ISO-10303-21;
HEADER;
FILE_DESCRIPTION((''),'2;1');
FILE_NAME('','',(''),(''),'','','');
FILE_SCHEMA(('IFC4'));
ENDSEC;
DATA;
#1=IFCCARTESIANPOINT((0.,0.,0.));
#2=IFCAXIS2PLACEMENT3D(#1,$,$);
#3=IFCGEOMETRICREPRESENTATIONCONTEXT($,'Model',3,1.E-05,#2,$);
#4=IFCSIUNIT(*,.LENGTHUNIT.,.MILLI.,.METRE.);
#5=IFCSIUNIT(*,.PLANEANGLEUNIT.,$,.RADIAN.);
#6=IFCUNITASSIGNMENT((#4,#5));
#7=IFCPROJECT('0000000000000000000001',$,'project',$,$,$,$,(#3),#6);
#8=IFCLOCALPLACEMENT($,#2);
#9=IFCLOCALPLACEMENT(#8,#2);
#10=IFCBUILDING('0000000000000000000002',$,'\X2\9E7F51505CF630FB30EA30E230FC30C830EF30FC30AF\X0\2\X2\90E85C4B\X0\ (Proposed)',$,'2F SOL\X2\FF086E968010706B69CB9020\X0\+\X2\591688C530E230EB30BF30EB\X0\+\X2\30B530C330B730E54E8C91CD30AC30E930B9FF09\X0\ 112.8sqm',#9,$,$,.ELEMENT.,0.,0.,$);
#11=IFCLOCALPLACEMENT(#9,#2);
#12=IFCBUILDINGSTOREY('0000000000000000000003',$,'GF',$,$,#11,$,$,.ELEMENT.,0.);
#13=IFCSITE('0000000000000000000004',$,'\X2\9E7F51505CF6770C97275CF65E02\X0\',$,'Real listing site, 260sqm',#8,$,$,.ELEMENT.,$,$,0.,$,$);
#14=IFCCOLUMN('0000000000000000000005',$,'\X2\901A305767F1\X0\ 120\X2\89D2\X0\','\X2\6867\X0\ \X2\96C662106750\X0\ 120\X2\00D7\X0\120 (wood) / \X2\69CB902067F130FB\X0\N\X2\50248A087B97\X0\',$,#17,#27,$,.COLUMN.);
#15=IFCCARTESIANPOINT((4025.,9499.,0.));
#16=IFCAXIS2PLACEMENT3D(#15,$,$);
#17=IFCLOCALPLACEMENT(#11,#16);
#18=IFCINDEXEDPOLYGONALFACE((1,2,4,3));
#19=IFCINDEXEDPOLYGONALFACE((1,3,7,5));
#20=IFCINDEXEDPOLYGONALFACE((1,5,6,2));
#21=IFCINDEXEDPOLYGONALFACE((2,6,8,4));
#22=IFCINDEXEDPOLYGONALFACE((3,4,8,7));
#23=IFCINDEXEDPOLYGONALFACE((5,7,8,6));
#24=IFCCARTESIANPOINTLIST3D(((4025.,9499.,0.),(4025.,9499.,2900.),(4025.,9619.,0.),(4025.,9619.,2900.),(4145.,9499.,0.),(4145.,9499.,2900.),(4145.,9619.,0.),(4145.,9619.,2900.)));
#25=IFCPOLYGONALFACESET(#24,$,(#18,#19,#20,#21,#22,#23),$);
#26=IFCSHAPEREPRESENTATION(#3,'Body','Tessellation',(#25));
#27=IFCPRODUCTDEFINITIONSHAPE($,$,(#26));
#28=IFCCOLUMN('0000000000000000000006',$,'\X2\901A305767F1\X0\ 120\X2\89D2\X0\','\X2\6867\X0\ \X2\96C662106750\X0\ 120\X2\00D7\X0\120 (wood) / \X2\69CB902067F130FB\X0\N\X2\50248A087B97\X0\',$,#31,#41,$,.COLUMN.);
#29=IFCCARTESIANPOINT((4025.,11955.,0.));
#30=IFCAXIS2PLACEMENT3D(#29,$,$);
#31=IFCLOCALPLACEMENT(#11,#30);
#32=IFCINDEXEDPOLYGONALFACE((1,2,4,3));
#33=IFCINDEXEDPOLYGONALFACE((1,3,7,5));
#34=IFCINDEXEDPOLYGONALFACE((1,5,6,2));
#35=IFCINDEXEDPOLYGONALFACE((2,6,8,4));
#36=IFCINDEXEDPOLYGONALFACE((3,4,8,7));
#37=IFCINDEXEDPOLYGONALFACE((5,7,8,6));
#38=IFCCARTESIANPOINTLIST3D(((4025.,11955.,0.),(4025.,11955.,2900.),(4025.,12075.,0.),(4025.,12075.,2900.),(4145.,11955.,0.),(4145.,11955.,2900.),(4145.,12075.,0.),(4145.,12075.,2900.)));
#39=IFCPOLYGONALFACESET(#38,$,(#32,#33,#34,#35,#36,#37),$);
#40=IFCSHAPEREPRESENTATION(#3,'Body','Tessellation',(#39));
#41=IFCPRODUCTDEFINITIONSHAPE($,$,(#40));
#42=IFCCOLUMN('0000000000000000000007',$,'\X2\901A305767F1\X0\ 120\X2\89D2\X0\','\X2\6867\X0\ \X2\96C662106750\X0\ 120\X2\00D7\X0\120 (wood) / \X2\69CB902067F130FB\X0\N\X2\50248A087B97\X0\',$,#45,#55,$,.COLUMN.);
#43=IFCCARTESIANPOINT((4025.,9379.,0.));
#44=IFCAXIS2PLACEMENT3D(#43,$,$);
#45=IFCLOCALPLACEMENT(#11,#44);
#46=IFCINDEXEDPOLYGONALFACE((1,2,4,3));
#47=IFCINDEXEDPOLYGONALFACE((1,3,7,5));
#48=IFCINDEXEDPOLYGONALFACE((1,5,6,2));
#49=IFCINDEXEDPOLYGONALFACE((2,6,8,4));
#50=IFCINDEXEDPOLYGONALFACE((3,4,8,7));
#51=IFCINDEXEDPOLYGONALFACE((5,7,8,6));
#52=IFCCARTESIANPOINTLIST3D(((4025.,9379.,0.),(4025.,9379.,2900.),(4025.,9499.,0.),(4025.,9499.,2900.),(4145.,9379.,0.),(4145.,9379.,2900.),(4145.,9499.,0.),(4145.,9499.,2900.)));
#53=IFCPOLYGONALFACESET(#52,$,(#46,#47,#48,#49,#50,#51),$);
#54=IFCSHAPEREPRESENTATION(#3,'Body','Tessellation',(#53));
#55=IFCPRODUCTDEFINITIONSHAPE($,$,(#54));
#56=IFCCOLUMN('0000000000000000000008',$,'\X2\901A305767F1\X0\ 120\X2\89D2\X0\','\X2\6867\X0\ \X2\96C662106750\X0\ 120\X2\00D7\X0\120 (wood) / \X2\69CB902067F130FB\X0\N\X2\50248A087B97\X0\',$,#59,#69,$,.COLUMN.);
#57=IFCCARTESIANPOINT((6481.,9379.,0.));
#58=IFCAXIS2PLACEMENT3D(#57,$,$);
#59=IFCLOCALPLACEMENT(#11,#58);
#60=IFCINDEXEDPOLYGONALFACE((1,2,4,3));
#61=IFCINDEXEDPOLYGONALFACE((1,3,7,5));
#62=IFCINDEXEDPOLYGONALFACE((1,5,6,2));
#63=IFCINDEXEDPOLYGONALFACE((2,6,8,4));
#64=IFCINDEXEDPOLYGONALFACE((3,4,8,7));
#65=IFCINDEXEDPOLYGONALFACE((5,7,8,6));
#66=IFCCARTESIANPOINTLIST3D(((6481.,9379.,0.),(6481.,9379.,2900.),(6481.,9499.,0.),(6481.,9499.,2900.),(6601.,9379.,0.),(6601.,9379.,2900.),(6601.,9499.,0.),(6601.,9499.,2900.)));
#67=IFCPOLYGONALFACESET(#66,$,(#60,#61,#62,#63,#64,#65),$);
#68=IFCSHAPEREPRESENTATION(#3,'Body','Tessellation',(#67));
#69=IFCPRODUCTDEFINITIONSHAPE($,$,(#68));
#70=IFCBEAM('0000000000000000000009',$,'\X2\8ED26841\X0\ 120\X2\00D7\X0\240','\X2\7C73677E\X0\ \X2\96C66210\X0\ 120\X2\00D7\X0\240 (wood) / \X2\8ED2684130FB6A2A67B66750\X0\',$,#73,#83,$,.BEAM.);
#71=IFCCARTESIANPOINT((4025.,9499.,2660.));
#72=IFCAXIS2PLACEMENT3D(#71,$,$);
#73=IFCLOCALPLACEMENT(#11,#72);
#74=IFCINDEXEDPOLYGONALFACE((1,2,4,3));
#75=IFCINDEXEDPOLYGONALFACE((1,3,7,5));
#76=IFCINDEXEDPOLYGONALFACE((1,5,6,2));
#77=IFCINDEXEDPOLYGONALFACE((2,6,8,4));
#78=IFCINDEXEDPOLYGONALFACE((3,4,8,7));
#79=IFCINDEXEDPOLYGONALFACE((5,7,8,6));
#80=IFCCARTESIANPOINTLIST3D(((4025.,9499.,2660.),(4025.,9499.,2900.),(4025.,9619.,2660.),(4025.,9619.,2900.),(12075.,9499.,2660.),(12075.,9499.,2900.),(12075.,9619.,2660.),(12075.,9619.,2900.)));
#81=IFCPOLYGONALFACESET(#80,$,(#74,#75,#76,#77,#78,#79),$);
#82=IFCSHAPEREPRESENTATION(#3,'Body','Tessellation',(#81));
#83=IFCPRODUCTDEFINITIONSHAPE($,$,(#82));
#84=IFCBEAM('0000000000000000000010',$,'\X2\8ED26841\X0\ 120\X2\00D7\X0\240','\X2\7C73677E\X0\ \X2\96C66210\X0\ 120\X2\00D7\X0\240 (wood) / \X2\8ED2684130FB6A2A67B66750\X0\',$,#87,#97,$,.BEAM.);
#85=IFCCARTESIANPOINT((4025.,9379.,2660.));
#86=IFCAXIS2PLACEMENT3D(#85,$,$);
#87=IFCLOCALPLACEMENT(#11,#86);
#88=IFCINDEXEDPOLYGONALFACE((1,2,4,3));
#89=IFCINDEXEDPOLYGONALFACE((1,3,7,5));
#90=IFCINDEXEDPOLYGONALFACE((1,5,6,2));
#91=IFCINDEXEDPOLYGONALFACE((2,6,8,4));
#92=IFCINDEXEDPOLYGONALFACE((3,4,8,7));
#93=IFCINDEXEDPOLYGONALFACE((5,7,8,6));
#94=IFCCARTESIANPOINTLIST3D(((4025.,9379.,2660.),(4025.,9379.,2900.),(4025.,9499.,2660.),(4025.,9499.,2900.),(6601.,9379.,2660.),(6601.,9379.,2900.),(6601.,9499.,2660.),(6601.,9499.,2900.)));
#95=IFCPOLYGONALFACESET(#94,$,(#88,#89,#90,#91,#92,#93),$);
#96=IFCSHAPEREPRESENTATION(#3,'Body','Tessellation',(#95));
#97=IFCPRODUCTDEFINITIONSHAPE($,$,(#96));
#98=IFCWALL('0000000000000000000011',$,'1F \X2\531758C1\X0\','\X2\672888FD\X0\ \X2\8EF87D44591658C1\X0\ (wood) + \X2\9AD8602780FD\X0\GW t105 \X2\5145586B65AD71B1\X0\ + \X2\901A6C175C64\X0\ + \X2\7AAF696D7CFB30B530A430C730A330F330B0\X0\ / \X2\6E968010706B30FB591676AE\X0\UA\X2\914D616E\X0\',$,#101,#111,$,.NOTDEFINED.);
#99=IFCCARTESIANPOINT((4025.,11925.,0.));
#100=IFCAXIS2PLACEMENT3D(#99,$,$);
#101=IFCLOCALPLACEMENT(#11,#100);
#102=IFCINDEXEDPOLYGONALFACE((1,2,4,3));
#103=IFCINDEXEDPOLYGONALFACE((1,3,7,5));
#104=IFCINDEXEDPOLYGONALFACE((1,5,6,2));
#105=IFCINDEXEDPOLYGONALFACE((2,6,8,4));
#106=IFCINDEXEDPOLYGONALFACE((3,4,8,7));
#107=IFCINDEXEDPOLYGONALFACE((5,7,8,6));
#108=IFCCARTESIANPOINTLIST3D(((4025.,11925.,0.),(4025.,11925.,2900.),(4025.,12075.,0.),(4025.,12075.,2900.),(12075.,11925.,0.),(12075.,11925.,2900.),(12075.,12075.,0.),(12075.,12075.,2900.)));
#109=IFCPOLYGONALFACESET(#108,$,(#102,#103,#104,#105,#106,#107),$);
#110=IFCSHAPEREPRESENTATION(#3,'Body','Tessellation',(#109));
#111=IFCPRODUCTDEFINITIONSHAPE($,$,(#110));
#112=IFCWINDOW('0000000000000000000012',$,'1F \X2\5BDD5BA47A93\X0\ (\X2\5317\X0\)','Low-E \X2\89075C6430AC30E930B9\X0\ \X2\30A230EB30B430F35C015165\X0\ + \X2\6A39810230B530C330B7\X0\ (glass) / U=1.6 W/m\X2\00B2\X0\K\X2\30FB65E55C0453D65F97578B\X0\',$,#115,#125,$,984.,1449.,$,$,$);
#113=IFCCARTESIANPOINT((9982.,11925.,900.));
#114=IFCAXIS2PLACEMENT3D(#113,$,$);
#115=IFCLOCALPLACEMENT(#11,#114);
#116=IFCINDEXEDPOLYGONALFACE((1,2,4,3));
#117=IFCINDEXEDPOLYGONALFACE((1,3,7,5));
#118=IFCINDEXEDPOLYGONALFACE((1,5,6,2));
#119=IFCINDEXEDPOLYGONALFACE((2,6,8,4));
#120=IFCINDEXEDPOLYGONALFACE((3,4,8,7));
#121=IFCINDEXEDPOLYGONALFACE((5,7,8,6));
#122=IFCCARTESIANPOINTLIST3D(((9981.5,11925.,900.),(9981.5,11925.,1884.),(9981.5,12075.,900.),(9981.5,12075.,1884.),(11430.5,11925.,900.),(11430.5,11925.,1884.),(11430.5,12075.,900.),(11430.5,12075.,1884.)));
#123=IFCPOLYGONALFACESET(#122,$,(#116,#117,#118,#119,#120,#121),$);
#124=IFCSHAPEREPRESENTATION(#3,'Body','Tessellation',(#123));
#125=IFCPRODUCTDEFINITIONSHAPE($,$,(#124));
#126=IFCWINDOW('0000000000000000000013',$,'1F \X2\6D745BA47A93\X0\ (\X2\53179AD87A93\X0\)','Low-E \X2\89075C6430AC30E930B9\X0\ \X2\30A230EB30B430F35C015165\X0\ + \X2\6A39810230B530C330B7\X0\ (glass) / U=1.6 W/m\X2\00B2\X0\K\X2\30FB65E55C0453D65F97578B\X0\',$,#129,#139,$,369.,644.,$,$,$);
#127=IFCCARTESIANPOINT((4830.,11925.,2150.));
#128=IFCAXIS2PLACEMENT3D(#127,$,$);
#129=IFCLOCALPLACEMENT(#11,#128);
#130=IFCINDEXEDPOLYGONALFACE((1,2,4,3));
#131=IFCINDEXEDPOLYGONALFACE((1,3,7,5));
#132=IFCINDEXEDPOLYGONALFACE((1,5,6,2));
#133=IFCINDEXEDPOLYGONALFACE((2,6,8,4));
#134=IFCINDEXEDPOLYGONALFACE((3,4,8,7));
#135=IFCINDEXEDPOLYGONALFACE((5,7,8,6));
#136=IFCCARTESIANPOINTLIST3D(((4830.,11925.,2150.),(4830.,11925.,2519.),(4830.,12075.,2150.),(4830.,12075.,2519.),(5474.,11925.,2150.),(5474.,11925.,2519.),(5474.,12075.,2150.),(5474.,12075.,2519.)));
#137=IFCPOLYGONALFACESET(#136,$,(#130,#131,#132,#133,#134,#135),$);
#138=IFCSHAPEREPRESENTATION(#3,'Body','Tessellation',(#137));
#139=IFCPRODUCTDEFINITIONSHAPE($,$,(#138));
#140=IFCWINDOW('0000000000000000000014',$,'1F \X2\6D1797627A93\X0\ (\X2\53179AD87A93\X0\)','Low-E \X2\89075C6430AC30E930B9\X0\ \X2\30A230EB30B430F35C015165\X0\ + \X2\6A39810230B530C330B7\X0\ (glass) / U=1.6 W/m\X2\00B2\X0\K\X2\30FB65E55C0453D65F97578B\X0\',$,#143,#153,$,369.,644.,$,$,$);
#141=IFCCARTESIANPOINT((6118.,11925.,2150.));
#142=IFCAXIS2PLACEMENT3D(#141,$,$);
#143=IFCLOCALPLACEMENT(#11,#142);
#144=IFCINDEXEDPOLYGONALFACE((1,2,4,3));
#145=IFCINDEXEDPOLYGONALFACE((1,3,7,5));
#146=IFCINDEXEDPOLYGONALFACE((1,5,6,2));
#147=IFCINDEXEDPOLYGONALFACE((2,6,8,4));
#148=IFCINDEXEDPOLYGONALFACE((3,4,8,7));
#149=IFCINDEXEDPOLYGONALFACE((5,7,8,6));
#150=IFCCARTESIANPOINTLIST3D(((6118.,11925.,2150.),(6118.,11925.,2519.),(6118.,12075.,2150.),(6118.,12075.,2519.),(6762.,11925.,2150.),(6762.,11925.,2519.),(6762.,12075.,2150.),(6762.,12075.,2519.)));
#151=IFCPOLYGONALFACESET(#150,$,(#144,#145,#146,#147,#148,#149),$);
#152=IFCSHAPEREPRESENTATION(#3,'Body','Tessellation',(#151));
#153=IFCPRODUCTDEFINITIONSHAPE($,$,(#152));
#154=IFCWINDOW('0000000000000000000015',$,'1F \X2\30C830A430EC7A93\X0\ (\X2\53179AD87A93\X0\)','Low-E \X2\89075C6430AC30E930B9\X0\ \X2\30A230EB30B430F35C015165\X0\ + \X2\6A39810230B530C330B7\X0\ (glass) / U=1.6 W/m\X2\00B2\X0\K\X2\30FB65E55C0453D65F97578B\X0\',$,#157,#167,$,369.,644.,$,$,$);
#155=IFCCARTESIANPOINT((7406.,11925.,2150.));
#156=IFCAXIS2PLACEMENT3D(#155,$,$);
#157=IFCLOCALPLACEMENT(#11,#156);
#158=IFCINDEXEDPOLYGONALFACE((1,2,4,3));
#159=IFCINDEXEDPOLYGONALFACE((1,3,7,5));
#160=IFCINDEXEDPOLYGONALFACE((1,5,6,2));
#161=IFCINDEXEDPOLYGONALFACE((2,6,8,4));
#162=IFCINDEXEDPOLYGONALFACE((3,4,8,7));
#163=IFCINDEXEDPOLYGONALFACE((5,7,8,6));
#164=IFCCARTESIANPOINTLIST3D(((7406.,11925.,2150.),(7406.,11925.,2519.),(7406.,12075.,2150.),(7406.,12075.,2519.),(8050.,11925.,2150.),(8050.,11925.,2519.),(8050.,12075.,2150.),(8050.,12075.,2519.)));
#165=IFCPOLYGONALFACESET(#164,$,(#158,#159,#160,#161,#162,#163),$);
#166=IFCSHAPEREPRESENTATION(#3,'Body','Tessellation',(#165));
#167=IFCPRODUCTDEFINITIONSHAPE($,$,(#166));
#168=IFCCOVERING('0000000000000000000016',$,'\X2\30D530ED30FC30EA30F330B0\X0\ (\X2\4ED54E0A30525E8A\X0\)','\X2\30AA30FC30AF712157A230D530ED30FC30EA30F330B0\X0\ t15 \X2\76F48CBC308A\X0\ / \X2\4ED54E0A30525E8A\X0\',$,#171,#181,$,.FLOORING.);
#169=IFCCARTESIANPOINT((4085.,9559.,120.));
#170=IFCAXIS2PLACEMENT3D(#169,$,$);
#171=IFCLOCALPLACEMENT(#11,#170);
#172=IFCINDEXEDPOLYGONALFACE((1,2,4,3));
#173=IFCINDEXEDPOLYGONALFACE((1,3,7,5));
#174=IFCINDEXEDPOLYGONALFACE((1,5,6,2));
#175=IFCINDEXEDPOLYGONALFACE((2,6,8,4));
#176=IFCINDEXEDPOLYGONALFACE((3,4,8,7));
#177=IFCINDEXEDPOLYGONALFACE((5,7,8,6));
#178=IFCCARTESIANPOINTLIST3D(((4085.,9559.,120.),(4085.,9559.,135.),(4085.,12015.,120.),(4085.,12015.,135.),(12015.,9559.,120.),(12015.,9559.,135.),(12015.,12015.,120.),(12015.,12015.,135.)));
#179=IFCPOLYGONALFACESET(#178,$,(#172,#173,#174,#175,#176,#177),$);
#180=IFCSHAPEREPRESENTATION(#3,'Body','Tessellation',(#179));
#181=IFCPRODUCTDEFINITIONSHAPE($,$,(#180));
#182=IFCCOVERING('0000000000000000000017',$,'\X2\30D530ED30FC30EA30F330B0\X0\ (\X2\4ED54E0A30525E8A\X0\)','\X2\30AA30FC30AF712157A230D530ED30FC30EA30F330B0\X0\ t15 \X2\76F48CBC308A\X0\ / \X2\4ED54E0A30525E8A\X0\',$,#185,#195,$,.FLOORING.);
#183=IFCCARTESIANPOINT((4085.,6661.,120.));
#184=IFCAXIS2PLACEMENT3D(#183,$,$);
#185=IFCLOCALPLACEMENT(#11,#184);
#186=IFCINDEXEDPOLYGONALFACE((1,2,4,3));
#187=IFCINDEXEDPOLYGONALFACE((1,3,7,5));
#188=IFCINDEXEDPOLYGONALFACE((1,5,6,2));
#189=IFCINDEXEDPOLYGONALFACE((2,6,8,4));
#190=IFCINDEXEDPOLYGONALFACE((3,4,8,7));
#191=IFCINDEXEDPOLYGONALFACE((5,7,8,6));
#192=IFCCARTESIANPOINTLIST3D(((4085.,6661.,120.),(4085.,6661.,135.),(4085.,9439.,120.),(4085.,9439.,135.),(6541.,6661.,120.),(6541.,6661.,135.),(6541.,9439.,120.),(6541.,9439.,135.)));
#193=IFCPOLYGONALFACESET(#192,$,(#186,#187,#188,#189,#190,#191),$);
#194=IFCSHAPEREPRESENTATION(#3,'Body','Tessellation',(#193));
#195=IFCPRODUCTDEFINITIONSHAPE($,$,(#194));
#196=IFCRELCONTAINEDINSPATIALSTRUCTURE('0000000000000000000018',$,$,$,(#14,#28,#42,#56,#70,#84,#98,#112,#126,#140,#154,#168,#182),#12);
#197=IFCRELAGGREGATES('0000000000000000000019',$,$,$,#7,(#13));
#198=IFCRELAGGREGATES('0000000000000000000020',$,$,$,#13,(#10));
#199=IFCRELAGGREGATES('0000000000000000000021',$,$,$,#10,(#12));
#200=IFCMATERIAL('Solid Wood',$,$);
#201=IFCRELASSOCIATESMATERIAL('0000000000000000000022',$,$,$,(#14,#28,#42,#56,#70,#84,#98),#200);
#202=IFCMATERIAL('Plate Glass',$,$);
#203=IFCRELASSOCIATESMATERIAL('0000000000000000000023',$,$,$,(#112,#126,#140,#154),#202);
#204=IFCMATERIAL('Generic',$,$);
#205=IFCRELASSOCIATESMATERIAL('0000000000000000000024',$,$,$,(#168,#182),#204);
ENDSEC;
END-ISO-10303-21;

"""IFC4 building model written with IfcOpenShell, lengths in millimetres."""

from ifc_helpers import new_model, si_unit, frame, frame_2d, origin, place, context, project, spatial, rectangle, extrude, material, element, fill, save


model = new_model("IFC4")

# Units and contexts
model_context = context("Model", 3, precision=1e-05, world=origin())
ifc_project = project(units=[si_unit("LENGTHUNIT", "METRE", prefix="MILLI"), si_unit("PLANEANGLEUNIT", "RADIAN")], contexts=[model_context])

# Site, building, storey
site_placement = place(None, origin())
site = spatial("IfcSite", under=ifc_project, at=site_placement, Name="鹿児島県霧島市", ObjectType="Real listing site, 260sqm", CompositionType="ELEMENT", RefElevation=0.0)
building_placement = place(site_placement, origin())
building = spatial("IfcBuilding", under=site, at=building_placement, Name="鹿児島・リモートワーク2部屋 (Proposed)", ObjectType="2F SOL（準耐火構造+外装モルタル+サッシュ二重ガラス） 112.8sqm", CompositionType="ELEMENT", ElevationOfRefHeight=0.0, ElevationOfTerrain=0.0)
storey_placement = place(building_placement, origin())
storey = spatial("IfcBuildingStorey", under=building, at=storey_placement, Name="GF", CompositionType="ELEMENT", Elevation=0.0)

# Columns
ifc_material_1 = material(Name="Solid Wood")
column_1_placement = place(storey_placement, frame((4025.0, 9499.0, 0.0)))
element("IfcColumn", 1, at=column_1_placement, inside=storey, material=ifc_material_1, Name="通し柱 120角", Description="桧 集成材 120×120 (wood) / 構造柱・N値計算", PredefinedType="COLUMN", context=model_context, shape_type="SweptSolid", body=[
    extrude(rectangle(XDim=120.0, YDim=120.0, at=frame_2d((60.0, 60.0))), frame((4025.0, 9499.0, 0.0)), (0.0, 0.0, 1.0), 2900.0),
])
column_2_placement = place(storey_placement, frame((4025.0, 11955.0, 0.0)))
element("IfcColumn", 2, at=column_2_placement, inside=storey, material=ifc_material_1, Name="通し柱 120角", Description="桧 集成材 120×120 (wood) / 構造柱・N値計算", PredefinedType="COLUMN", context=model_context, shape_type="SweptSolid", body=[
    extrude(rectangle(XDim=120.0, YDim=120.0, at=frame_2d((60.0, 60.0))), frame((4025.0, 11955.0, 0.0)), (0.0, 0.0, 1.0), 2900.0),
])
column_3_placement = place(storey_placement, frame((4025.0, 9379.0, 0.0)))
element("IfcColumn", 3, at=column_3_placement, inside=storey, material=ifc_material_1, Name="通し柱 120角", Description="桧 集成材 120×120 (wood) / 構造柱・N値計算", PredefinedType="COLUMN", context=model_context, shape_type="SweptSolid", body=[
    extrude(rectangle(XDim=120.0, YDim=120.0, at=frame_2d((60.0, 60.0))), frame((4025.0, 9379.0, 0.0)), (0.0, 0.0, 1.0), 2900.0),
])
column_4_placement = place(storey_placement, frame((6481.0, 9379.0, 0.0)))
element("IfcColumn", 4, at=column_4_placement, inside=storey, material=ifc_material_1, Name="通し柱 120角", Description="桧 集成材 120×120 (wood) / 構造柱・N値計算", PredefinedType="COLUMN", context=model_context, shape_type="SweptSolid", body=[
    extrude(rectangle(XDim=120.0, YDim=120.0, at=frame_2d((60.0, 60.0))), frame((6481.0, 9379.0, 0.0)), (0.0, 0.0, 1.0), 2900.0),
])

# Beams
beam_1_placement = place(storey_placement, frame((4025.0, 9499.0, 2660.0)))
element("IfcBeam", 5, at=beam_1_placement, inside=storey, material=ifc_material_1, Name="軒桁 120×240", Description="米松 集成 120×240 (wood) / 軒桁・横架材", PredefinedType="BEAM", context=model_context, shape_type="SweptSolid", body=[
    extrude(rectangle(XDim=8050.0, YDim=120.0, at=frame_2d((4025.0, 60.0))), frame((4025.0, 9499.0, 2660.0)), (0.0, 0.0, 1.0), 240.0),
])
beam_2_placement = place(storey_placement, frame((4025.0, 9379.0, 2660.0)))
element("IfcBeam", 6, at=beam_2_placement, inside=storey, material=ifc_material_1, Name="軒桁 120×240", Description="米松 集成 120×240 (wood) / 軒桁・横架材", PredefinedType="BEAM", context=model_context, shape_type="SweptSolid", body=[
    extrude(rectangle(XDim=2576.0, YDim=120.0, at=frame_2d((1288.0, 60.0))), frame((4025.0, 9379.0, 2660.0)), (0.0, 0.0, 1.0), 240.0),
])

# Wall, openings, windows
wall_1_placement = place(storey_placement, frame((4025.0, 11925.0, 0.0)))
wall_1 = element("IfcWall", 7, at=wall_1_placement, inside=storey, material=ifc_material_1, Name="1F 北壁", Description="木製 軸組外壁 (wood) + 高性能GW t105 充填断熱 + 通気層 + 窯業系サイディング / 準耐火・外皮UA配慮", PredefinedType="NOTDEFINED", context=model_context, shape_type="SweptSolid", body=[
    extrude(rectangle(XDim=8050.0, YDim=150.0, at=frame_2d((4025.0, 75.0))), frame((4025.0, 11925.0, 0.0)), (0.0, 0.0, 1.0), 2900.0),
])
opening_1_placement = place(storey_placement, frame((9982.0, 11925.0, 900.0)))
opening_1 = element("IfcOpeningElement", 8, at=opening_1_placement, cuts=wall_1, PredefinedType="NOTDEFINED", context=model_context, shape_type="SweptSolid", body=[
    extrude(rectangle(XDim=1449.0, YDim=150.0, at=frame_2d((724.0, 75.0))), frame((9982.0, 11925.0, 900.0)), (0.0, 0.0, 1.0), 984.0),
])
opening_2_placement = place(storey_placement, frame((4830.0, 11925.0, 2150.0)))
opening_2 = element("IfcOpeningElement", 9, at=opening_2_placement, cuts=wall_1, PredefinedType="NOTDEFINED", context=model_context, shape_type="SweptSolid", body=[
    extrude(rectangle(XDim=644.0, YDim=150.0, at=frame_2d((322.0, 75.0))), frame((4830.0, 11925.0, 2150.0)), (0.0, 0.0, 1.0), 369.0),
])
opening_3_placement = place(storey_placement, frame((6118.0, 11925.0, 2150.0)))
opening_3 = element("IfcOpeningElement", 10, at=opening_3_placement, cuts=wall_1, PredefinedType="NOTDEFINED", context=model_context, shape_type="SweptSolid", body=[
    extrude(rectangle(XDim=644.0, YDim=150.0, at=frame_2d((322.0, 75.0))), frame((6118.0, 11925.0, 2150.0)), (0.0, 0.0, 1.0), 369.0),
])
opening_4_placement = place(storey_placement, frame((7406.0, 11925.0, 2150.0)))
opening_4 = element("IfcOpeningElement", 11, at=opening_4_placement, cuts=wall_1, PredefinedType="NOTDEFINED", context=model_context, shape_type="SweptSolid", body=[
    extrude(rectangle(XDim=644.0, YDim=150.0, at=frame_2d((322.0, 75.0))), frame((7406.0, 11925.0, 2150.0)), (0.0, 0.0, 1.0), 369.0),
])
ifc_material_2 = material(Name="Plate Glass")
window_1_placement = place(storey_placement, frame((9982.0, 11925.0, 900.0)))
window_1 = element("IfcWindow", 12, at=window_1_placement, inside=storey, material=ifc_material_2, Name="1F 寝室窓 (北)", Description="Low-E 複層ガラス アルゴン封入 + 樹脂サッシ (glass) / U=1.6 W/m²K・日射取得型", OverallHeight=984.0, OverallWidth=1449.0, context=model_context, shape_type="SweptSolid", body=[
    extrude(rectangle(XDim=1449.0, YDim=150.0, at=frame_2d((724.0, 75.0))), frame((9982.0, 11925.0, 900.0)), (0.0, 0.0, 1.0), 984.0),
])
fill(opening_1, window_1)
window_2_placement = place(storey_placement, frame((4830.0, 11925.0, 2150.0)))
window_2 = element("IfcWindow", 13, at=window_2_placement, inside=storey, material=ifc_material_2, Name="1F 浴室窓 (北高窓)", Description="Low-E 複層ガラス アルゴン封入 + 樹脂サッシ (glass) / U=1.6 W/m²K・日射取得型", OverallHeight=369.0, OverallWidth=644.0, context=model_context, shape_type="SweptSolid", body=[
    extrude(rectangle(XDim=644.0, YDim=150.0, at=frame_2d((322.0, 75.0))), frame((4830.0, 11925.0, 2150.0)), (0.0, 0.0, 1.0), 369.0),
])
fill(opening_2, window_2)
window_3_placement = place(storey_placement, frame((6118.0, 11925.0, 2150.0)))
window_3 = element("IfcWindow", 14, at=window_3_placement, inside=storey, material=ifc_material_2, Name="1F 洗面窓 (北高窓)", Description="Low-E 複層ガラス アルゴン封入 + 樹脂サッシ (glass) / U=1.6 W/m²K・日射取得型", OverallHeight=369.0, OverallWidth=644.0, context=model_context, shape_type="SweptSolid", body=[
    extrude(rectangle(XDim=644.0, YDim=150.0, at=frame_2d((322.0, 75.0))), frame((6118.0, 11925.0, 2150.0)), (0.0, 0.0, 1.0), 369.0),
])
fill(opening_3, window_3)
window_4_placement = place(storey_placement, frame((7406.0, 11925.0, 2150.0)))
window_4 = element("IfcWindow", 15, at=window_4_placement, inside=storey, material=ifc_material_2, Name="1F トイレ窓 (北高窓)", Description="Low-E 複層ガラス アルゴン封入 + 樹脂サッシ (glass) / U=1.6 W/m²K・日射取得型", OverallHeight=369.0, OverallWidth=644.0, context=model_context, shape_type="SweptSolid", body=[
    extrude(rectangle(XDim=644.0, YDim=150.0, at=frame_2d((322.0, 75.0))), frame((7406.0, 11925.0, 2150.0)), (0.0, 0.0, 1.0), 369.0),
])
fill(opening_4, window_4)

# Coverings
ifc_material_3 = material(Name="Generic")
covering_1_placement = place(storey_placement, frame((4085.0, 9559.0, 120.0)))
element("IfcCovering", 16, at=covering_1_placement, inside=storey, material=ifc_material_3, Name="フローリング (仕上げ床)", Description="オーク無垢フローリング t15 直貼り / 仕上げ床", PredefinedType="FLOORING", context=model_context, shape_type="SweptSolid", body=[
    extrude(rectangle(XDim=7930.0, YDim=2456.0, at=frame_2d((3965.0, 1228.0))), frame((4085.0, 9559.0, 120.0)), (0.0, 0.0, 1.0), 15.0),
])
covering_2_placement = place(storey_placement, frame((4085.0, 6661.0, 120.0)))
element("IfcCovering", 17, at=covering_2_placement, inside=storey, material=ifc_material_3, Name="フローリング (仕上げ床)", Description="オーク無垢フローリング t15 直貼り / 仕上げ床", PredefinedType="FLOORING", context=model_context, shape_type="SweptSolid", body=[
    extrude(rectangle(XDim=2456.0, YDim=2778.0, at=frame_2d((1228.0, 1389.0))), frame((4085.0, 6661.0, 120.0)), (0.0, 0.0, 1.0), 15.0),
])

save(model, "model.ifc")
